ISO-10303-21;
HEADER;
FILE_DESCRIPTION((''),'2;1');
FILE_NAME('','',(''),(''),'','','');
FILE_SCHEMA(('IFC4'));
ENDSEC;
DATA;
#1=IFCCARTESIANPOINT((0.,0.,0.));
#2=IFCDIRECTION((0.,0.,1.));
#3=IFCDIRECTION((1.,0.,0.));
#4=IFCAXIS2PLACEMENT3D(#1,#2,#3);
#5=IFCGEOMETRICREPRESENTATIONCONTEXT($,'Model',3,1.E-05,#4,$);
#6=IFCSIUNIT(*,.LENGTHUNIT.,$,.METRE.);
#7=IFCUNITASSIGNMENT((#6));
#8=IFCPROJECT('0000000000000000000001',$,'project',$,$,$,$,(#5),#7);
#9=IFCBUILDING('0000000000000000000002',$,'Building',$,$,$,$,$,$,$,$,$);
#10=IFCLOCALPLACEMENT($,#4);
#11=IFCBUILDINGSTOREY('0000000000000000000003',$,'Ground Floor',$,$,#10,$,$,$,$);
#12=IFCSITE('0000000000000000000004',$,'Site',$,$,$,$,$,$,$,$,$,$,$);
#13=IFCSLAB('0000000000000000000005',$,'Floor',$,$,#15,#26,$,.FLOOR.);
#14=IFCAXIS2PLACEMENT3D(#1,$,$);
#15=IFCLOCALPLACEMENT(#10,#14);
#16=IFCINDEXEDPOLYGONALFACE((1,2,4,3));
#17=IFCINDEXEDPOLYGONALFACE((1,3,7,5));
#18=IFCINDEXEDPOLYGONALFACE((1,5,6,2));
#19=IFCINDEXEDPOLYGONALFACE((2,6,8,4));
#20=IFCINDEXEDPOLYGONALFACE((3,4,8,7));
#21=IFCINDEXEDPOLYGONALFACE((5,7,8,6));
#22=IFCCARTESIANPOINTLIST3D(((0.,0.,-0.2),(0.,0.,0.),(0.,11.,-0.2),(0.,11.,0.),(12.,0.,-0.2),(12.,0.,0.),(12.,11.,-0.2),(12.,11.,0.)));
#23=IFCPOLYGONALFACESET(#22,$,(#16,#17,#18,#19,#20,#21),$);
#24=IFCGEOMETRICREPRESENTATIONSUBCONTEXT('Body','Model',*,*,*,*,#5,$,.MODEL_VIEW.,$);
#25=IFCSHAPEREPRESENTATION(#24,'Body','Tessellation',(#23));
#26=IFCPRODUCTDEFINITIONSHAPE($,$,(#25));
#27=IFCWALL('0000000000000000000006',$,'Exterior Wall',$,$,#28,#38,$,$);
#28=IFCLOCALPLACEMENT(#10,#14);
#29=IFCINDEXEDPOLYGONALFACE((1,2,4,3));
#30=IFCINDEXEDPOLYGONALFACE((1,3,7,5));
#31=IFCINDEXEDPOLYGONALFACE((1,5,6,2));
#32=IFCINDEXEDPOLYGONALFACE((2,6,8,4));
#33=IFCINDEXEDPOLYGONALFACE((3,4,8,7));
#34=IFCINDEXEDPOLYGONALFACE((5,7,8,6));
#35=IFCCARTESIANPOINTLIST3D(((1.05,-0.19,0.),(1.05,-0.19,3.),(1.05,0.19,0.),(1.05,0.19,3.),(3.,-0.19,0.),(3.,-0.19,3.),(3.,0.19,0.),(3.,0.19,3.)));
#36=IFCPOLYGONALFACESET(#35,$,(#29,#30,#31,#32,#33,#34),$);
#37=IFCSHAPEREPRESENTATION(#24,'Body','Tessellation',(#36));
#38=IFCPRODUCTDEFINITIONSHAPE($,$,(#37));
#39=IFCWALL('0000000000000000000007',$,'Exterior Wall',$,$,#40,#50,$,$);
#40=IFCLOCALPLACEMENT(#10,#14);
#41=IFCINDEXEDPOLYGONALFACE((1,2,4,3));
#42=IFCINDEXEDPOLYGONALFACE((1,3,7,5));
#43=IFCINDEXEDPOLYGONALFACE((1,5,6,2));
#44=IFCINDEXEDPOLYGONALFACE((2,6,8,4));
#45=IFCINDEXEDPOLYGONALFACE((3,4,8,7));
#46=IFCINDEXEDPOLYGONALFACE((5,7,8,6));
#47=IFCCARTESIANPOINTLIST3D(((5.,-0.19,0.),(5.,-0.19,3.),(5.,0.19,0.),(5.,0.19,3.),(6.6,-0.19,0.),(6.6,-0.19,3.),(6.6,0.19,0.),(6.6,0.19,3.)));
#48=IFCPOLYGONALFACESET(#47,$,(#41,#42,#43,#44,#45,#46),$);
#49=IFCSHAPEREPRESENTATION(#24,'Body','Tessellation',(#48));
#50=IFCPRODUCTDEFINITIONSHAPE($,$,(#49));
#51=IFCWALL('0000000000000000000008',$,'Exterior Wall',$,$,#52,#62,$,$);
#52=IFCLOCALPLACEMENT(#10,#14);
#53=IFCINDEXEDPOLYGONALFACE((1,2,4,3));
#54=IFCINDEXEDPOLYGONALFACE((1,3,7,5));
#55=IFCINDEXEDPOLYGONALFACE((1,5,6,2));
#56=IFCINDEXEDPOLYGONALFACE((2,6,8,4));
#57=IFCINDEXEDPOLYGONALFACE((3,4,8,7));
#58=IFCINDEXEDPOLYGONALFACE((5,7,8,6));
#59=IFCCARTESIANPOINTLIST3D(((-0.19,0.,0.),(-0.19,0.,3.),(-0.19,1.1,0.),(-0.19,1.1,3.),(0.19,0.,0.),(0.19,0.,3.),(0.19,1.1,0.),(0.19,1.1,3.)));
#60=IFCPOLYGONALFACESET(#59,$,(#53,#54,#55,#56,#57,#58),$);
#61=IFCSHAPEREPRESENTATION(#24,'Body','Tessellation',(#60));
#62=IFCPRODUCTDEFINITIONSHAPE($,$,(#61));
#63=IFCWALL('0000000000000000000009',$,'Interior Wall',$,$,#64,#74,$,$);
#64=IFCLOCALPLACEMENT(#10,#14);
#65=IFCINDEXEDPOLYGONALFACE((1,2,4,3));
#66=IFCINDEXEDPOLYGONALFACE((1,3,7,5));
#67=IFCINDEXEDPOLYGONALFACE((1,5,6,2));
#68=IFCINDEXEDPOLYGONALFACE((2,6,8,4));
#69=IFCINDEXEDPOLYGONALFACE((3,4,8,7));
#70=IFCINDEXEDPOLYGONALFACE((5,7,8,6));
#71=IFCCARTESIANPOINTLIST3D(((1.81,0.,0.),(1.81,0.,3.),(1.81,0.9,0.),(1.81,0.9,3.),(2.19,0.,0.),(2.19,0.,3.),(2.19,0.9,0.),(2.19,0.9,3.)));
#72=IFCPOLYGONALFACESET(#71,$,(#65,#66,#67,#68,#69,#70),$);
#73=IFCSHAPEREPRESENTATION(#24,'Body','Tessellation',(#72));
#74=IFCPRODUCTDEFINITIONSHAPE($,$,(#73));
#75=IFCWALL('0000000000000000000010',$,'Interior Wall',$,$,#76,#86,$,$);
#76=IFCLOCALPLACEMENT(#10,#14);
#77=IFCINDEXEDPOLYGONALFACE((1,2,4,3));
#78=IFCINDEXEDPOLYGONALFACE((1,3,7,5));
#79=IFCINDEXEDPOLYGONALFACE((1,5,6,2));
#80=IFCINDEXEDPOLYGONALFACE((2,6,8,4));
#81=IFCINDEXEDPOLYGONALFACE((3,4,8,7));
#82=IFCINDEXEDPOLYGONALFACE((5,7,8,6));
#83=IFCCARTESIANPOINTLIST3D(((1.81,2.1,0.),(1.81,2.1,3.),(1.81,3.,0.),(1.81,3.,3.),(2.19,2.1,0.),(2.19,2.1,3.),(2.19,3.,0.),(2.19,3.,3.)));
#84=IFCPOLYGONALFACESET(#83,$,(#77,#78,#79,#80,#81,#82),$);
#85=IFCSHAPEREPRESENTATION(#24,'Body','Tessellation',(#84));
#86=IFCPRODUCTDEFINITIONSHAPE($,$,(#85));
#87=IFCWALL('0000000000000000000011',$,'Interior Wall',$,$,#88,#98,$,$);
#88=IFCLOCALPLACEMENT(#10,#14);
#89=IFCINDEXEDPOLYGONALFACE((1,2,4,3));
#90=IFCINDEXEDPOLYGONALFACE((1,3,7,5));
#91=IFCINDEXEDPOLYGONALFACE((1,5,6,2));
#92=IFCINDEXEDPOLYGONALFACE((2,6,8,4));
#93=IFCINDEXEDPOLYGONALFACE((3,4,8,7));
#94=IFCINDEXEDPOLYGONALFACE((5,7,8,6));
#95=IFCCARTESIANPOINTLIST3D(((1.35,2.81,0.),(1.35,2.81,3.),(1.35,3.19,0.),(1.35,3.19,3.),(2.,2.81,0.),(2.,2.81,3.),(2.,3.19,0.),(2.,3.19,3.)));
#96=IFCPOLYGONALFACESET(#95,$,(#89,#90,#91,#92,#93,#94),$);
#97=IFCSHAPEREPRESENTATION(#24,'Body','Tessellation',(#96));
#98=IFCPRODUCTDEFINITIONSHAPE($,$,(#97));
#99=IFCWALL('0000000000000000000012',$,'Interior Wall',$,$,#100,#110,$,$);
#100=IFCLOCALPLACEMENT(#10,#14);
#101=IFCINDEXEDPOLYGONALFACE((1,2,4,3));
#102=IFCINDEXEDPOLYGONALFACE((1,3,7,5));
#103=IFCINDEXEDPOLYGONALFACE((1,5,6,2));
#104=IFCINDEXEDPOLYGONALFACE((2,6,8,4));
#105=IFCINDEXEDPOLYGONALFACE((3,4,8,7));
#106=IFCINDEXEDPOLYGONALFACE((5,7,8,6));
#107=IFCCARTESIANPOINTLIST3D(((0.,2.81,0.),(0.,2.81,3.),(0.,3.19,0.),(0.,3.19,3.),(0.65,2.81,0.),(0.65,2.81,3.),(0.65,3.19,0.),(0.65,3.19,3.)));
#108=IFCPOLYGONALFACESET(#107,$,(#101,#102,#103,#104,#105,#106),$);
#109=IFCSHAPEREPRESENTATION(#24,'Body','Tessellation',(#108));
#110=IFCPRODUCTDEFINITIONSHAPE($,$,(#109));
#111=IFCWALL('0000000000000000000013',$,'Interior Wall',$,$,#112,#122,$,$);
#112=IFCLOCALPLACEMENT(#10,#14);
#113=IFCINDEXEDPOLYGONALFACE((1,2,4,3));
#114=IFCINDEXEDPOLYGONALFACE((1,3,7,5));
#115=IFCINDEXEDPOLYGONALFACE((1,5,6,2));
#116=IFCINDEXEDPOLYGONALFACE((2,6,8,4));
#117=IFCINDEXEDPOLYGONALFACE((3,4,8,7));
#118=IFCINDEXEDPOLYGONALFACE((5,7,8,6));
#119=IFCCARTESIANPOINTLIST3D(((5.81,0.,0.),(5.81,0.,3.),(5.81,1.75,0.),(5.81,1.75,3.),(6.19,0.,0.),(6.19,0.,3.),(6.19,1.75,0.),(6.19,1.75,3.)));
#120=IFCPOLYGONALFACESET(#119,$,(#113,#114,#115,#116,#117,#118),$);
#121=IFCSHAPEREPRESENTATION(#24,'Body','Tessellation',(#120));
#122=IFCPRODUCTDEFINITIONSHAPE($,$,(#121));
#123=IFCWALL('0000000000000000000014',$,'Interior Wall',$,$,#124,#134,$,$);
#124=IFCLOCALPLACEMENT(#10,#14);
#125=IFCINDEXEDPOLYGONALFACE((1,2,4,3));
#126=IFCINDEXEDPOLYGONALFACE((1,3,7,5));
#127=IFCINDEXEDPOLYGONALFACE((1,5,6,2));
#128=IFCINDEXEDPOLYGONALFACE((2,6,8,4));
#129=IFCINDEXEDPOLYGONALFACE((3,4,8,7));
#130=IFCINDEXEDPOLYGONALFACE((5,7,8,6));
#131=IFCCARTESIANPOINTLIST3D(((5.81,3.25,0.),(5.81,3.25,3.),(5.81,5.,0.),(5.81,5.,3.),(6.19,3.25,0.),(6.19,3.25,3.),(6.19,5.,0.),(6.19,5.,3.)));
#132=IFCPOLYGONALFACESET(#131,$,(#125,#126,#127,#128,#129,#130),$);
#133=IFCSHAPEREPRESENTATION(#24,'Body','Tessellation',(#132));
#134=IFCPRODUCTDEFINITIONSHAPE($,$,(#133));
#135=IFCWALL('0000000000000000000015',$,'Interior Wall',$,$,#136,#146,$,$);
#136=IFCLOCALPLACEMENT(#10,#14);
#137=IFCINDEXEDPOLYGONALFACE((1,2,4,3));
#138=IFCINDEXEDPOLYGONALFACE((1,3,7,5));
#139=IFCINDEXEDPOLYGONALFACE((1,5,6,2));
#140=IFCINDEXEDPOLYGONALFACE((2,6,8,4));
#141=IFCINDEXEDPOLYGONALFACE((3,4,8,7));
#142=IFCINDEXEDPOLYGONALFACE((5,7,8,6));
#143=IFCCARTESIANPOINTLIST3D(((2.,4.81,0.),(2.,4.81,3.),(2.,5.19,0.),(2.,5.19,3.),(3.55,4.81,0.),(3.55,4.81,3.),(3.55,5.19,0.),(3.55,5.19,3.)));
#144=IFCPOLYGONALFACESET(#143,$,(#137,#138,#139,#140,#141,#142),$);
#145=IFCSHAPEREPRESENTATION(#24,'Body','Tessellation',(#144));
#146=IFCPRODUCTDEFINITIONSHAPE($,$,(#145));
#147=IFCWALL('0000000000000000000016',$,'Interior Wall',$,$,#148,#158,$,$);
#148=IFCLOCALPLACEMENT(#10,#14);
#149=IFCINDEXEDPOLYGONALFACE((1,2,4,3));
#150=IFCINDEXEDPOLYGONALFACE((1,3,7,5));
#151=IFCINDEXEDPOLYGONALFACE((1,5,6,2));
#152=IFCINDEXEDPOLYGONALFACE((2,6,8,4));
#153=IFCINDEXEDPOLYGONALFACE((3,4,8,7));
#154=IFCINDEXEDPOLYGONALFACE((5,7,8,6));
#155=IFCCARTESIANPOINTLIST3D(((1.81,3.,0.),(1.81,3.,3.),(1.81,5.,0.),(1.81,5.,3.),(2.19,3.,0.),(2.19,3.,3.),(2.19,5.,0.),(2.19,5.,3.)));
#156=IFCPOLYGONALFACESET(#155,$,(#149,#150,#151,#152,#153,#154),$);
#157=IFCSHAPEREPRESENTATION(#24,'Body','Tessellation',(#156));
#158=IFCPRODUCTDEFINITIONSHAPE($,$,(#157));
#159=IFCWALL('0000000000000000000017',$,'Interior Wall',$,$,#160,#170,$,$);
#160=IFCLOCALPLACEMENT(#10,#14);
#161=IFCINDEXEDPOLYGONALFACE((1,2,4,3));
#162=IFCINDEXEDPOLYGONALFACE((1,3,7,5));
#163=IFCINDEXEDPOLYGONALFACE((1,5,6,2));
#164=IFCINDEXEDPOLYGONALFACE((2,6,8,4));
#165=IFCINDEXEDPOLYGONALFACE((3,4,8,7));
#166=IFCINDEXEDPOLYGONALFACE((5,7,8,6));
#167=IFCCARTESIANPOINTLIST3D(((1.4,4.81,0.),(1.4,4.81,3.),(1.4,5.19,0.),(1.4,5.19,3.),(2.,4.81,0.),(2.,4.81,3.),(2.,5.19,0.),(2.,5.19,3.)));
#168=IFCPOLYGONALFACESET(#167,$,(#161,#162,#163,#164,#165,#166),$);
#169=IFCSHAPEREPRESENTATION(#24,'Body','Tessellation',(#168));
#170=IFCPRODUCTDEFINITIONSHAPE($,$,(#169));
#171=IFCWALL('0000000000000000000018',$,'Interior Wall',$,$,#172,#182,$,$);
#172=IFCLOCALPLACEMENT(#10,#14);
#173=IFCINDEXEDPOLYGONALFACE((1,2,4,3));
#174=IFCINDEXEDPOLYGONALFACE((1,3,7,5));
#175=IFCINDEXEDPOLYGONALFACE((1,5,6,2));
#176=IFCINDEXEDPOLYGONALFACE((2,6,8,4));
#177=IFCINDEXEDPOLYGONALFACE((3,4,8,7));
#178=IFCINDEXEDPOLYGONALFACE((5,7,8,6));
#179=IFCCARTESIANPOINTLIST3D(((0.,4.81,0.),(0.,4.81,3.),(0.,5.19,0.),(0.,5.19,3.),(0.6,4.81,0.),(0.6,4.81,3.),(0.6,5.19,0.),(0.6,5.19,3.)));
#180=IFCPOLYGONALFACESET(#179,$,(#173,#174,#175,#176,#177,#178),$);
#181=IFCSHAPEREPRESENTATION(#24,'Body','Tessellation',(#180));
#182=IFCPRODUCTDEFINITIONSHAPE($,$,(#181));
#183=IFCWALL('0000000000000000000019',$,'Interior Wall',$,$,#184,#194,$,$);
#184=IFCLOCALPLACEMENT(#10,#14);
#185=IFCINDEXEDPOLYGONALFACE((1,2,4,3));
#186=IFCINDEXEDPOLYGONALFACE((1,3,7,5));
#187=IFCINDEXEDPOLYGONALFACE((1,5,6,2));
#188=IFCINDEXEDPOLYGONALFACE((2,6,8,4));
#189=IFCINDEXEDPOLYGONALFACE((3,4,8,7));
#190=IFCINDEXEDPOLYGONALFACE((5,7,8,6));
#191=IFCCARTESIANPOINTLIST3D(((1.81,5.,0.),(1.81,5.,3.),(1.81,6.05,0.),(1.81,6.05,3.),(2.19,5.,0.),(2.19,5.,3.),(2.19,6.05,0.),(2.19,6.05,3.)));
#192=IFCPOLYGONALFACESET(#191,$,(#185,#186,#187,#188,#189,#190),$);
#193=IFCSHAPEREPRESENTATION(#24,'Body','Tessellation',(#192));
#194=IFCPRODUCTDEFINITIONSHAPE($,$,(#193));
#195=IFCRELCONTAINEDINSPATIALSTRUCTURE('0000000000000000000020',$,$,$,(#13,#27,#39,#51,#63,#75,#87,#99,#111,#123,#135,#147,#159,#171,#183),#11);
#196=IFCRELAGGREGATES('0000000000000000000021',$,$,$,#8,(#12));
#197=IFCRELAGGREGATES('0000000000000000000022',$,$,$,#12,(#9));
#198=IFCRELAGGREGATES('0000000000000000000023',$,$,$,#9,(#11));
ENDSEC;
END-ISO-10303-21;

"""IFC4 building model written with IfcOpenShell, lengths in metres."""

from ifc_helpers import new_model, si_unit, frame, origin_with_axes, place, context, subcontext, project, spatial, indexed_curve, outline, extrude, element, save


model = new_model("IFC4")

# Units and contexts
model_context = context("Model", 3, precision=1e-05, world=origin_with_axes())
body_context = subcontext(model_context, "Body", "Model", "MODEL_VIEW")
ifc_project = project(units=[si_unit("LENGTHUNIT", "METRE")], contexts=[model_context])

# Site, building, storey
site = spatial("IfcSite", under=ifc_project, Name="Site")
building = spatial("IfcBuilding", under=site, Name="Building")
storey_placement = place(None, origin_with_axes())
storey = spatial("IfcBuildingStorey", under=building, at=storey_placement, Name="Ground Floor")

# Slab
slab_placement = place(storey_placement, frame((0.0, 0.0, -0.2), z_axis=(0.0, 0.0, 1.0), x_axis=(1.0, 0.0, 0.0)))
element("IfcSlab", 1, at=slab_placement, inside=storey, Name="Floor", PredefinedType="FLOOR", context=body_context, shape_type="SweptSolid", body=[
    extrude(outline(indexed_curve([(0.0, 0.0), (12.0, 0.0), (12.0, 11.0), (0.0, 11.0)])), None, (0.0, 0.0, 1.0), 0.2),
])

# Walls
wall_1_placement = place(storey_placement, frame((1.05, 0.0, 0.0), z_axis=(0.0, 0.0, 1.0), x_axis=(1.0, 0.0, 0.0)))
element("IfcWall", 2, at=wall_1_placement, inside=storey, Name="Exterior Wall", context=body_context, shape_type="SweptSolid", body=[
    extrude(outline(indexed_curve([(0.0, 0.0), (0.0, 0.38), (1.95, 0.38), (1.95, 0.0), (0.0, 0.0)], self_intersect=False)), frame((0.0, -0.19, 0.0), z_axis=(0.0, 0.0, 1.0), x_axis=(1.0, 0.0, 0.0)), (0.0, 0.0, 1.0), 3.0),
])
wall_2_placement = place(storey_placement, frame((5.0, 0.0, 0.0), z_axis=(0.0, 0.0, 1.0), x_axis=(1.0, 0.0, 0.0)))
element("IfcWall", 3, at=wall_2_placement, inside=storey, Name="Exterior Wall", context=body_context, shape_type="SweptSolid", body=[
    extrude(outline(indexed_curve([(0.0, 0.0), (0.0, 0.38), (1.6, 0.38), (1.6, 0.0), (0.0, 0.0)], self_intersect=False)), frame((0.0, -0.19, 0.0), z_axis=(0.0, 0.0, 1.0), x_axis=(1.0, 0.0, 0.0)), (0.0, 0.0, 1.0), 3.0),
])
wall_3_placement = place(storey_placement, frame((0.0, 1.1, 0.0), z_axis=(0.0, 0.0, 1.0), x_axis=(0.0, -1.0, 0.0)))
element("IfcWall", 4, at=wall_3_placement, inside=storey, Name="Exterior Wall", context=body_context, shape_type="SweptSolid", body=[
    extrude(outline(indexed_curve([(0.0, 0.0), (0.0, 0.38), (1.1, 0.38), (1.1, 0.0), (0.0, 0.0)], self_intersect=False)), frame((0.0, -0.19, 0.0), z_axis=(0.0, 0.0, 1.0), x_axis=(1.0, 0.0, 0.0)), (0.0, 0.0, 1.0), 3.0),
])
wall_4_placement = place(storey_placement, frame((2.0, 0.0, 0.0), z_axis=(0.0, 0.0, 1.0), x_axis=(0.0, 1.0, 0.0)))
element("IfcWall", 5, at=wall_4_placement, inside=storey, Name="Interior Wall", context=body_context, shape_type="SweptSolid", body=[
    extrude(outline(indexed_curve([(0.0, 0.0), (0.0, 0.38), (0.9, 0.38), (0.9, 0.0), (0.0, 0.0)], self_intersect=False)), frame((0.0, -0.19, 0.0), z_axis=(0.0, 0.0, 1.0), x_axis=(1.0, 0.0, 0.0)), (0.0, 0.0, 1.0), 3.0),
])
wall_5_placement = place(storey_placement, frame((2.0, 2.1, 0.0), z_axis=(0.0, 0.0, 1.0), x_axis=(0.0, 1.0, 0.0)))
element("IfcWall", 6, at=wall_5_placement, inside=storey, Name="Interior Wall", context=body_context, shape_type="SweptSolid", body=[
    extrude(outline(indexed_curve([(0.0, 0.0), (0.0, 0.38), (0.9, 0.38), (0.9, 0.0), (0.0, 0.0)], self_intersect=False)), frame((0.0, -0.19, 0.0), z_axis=(0.0, 0.0, 1.0), x_axis=(1.0, 0.0, 0.0)), (0.0, 0.0, 1.0), 3.0),
])
for number, where, z_axis, x_axis, name in (
    (7, (2.0, 3.0, 0.0), (0.0, 0.0, 1.0), (-1.0, 0.0, 0.0), "Interior Wall"),
    (8, (0.65, 3.0, 0.0), (0.0, 0.0, 1.0), (-1.0, 0.0, 0.0), "Interior Wall"),
):
    element("IfcWall", number, at=place(storey_placement, frame(where, z_axis=z_axis, x_axis=x_axis)), inside=storey, Name=name, context=body_context, shape_type="SweptSolid", body=[
        extrude(outline(indexed_curve([(0.0, 0.0), (0.0, 0.38), (0.65, 0.38), (0.65, 0.0), (0.0, 0.0)], self_intersect=False)), frame((0.0, -0.19, 0.0), z_axis=(0.0, 0.0, 1.0), x_axis=(1.0, 0.0, 0.0)), (0.0, 0.0, 1.0), 3.0),
    ])
for number, where, z_axis, x_axis, name in (
    (9, (6.0, 0.0, 0.0), (0.0, 0.0, 1.0), (0.0, 1.0, 0.0), "Interior Wall"),
    (10, (6.0, 3.25, 0.0), (0.0, 0.0, 1.0), (0.0, 1.0, 0.0), "Interior Wall"),
):
    element("IfcWall", number, at=place(storey_placement, frame(where, z_axis=z_axis, x_axis=x_axis)), inside=storey, Name=name, context=body_context, shape_type="SweptSolid", body=[
        extrude(outline(indexed_curve([(0.0, 0.0), (0.0, 0.38), (1.75, 0.38), (1.75, 0.0), (0.0, 0.0)], self_intersect=False)), frame((0.0, -0.19, 0.0), z_axis=(0.0, 0.0, 1.0), x_axis=(1.0, 0.0, 0.0)), (0.0, 0.0, 1.0), 3.0),
    ])
wall_6_placement = place(storey_placement, frame((3.55, 5.0, 0.0), z_axis=(0.0, 0.0, 1.0), x_axis=(-1.0, 0.0, 0.0)))
element("IfcWall", 11, at=wall_6_placement, inside=storey, Name="Interior Wall", context=body_context, shape_type="SweptSolid", body=[
    extrude(outline(indexed_curve([(0.0, 0.0), (0.0, 0.38), (1.55, 0.38), (1.55, 0.0), (0.0, 0.0)], self_intersect=False)), frame((0.0, -0.19, 0.0), z_axis=(0.0, 0.0, 1.0), x_axis=(1.0, 0.0, 0.0)), (0.0, 0.0, 1.0), 3.0),
])
wall_7_placement = place(storey_placement, frame((2.0, 5.0, 0.0), z_axis=(0.0, 0.0, 1.0), x_axis=(0.0, -1.0, 0.0)))
element("IfcWall", 12, at=wall_7_placement, inside=storey, Name="Interior Wall", context=body_context, shape_type="SweptSolid", body=[
    extrude(outline(indexed_curve([(0.0, 0.0), (0.0, 0.38), (2.0, 0.38), (2.0, 0.0), (0.0, 0.0)], self_intersect=False)), frame((0.0, -0.19, 0.0), z_axis=(0.0, 0.0, 1.0), x_axis=(1.0, 0.0, 0.0)), (0.0, 0.0, 1.0), 3.0),
])
for number, where, z_axis, x_axis, name in (
    (13, (2.0, 5.0, 0.0), (0.0, 0.0, 1.0), (-1.0, 0.0, 0.0), "Interior Wall"),
    (14, (0.6, 5.0, 0.0), (0.0, 0.0, 1.0), (-1.0, 0.0, 0.0), "Interior Wall"),
):
    element("IfcWall", number, at=place(storey_placement, frame(where, z_axis=z_axis, x_axis=x_axis)), inside=storey, Name=name, context=body_context, shape_type="SweptSolid", body=[
        extrude(outline(indexed_curve([(0.0, 0.0), (0.0, 0.38), (0.6, 0.38), (0.6, 0.0), (0.0, 0.0)], self_intersect=False)), frame((0.0, -0.19, 0.0), z_axis=(0.0, 0.0, 1.0), x_axis=(1.0, 0.0, 0.0)), (0.0, 0.0, 1.0), 3.0),
    ])
wall_8_placement = place(storey_placement, frame((2.0, 5.0, 0.0), z_axis=(0.0, 0.0, 1.0), x_axis=(0.0, 1.0, 0.0)))
element("IfcWall", 15, at=wall_8_placement, inside=storey, Name="Interior Wall", context=body_context, shape_type="SweptSolid", body=[
    extrude(outline(indexed_curve([(0.0, 0.0), (0.0, 0.38), (1.05, 0.38), (1.05, 0.0), (0.0, 0.0)], self_intersect=False)), frame((0.0, -0.19, 0.0), z_axis=(0.0, 0.0, 1.0), x_axis=(1.0, 0.0, 0.0)), (0.0, 0.0, 1.0), 3.0),
])

save(model, "model.ifc")
